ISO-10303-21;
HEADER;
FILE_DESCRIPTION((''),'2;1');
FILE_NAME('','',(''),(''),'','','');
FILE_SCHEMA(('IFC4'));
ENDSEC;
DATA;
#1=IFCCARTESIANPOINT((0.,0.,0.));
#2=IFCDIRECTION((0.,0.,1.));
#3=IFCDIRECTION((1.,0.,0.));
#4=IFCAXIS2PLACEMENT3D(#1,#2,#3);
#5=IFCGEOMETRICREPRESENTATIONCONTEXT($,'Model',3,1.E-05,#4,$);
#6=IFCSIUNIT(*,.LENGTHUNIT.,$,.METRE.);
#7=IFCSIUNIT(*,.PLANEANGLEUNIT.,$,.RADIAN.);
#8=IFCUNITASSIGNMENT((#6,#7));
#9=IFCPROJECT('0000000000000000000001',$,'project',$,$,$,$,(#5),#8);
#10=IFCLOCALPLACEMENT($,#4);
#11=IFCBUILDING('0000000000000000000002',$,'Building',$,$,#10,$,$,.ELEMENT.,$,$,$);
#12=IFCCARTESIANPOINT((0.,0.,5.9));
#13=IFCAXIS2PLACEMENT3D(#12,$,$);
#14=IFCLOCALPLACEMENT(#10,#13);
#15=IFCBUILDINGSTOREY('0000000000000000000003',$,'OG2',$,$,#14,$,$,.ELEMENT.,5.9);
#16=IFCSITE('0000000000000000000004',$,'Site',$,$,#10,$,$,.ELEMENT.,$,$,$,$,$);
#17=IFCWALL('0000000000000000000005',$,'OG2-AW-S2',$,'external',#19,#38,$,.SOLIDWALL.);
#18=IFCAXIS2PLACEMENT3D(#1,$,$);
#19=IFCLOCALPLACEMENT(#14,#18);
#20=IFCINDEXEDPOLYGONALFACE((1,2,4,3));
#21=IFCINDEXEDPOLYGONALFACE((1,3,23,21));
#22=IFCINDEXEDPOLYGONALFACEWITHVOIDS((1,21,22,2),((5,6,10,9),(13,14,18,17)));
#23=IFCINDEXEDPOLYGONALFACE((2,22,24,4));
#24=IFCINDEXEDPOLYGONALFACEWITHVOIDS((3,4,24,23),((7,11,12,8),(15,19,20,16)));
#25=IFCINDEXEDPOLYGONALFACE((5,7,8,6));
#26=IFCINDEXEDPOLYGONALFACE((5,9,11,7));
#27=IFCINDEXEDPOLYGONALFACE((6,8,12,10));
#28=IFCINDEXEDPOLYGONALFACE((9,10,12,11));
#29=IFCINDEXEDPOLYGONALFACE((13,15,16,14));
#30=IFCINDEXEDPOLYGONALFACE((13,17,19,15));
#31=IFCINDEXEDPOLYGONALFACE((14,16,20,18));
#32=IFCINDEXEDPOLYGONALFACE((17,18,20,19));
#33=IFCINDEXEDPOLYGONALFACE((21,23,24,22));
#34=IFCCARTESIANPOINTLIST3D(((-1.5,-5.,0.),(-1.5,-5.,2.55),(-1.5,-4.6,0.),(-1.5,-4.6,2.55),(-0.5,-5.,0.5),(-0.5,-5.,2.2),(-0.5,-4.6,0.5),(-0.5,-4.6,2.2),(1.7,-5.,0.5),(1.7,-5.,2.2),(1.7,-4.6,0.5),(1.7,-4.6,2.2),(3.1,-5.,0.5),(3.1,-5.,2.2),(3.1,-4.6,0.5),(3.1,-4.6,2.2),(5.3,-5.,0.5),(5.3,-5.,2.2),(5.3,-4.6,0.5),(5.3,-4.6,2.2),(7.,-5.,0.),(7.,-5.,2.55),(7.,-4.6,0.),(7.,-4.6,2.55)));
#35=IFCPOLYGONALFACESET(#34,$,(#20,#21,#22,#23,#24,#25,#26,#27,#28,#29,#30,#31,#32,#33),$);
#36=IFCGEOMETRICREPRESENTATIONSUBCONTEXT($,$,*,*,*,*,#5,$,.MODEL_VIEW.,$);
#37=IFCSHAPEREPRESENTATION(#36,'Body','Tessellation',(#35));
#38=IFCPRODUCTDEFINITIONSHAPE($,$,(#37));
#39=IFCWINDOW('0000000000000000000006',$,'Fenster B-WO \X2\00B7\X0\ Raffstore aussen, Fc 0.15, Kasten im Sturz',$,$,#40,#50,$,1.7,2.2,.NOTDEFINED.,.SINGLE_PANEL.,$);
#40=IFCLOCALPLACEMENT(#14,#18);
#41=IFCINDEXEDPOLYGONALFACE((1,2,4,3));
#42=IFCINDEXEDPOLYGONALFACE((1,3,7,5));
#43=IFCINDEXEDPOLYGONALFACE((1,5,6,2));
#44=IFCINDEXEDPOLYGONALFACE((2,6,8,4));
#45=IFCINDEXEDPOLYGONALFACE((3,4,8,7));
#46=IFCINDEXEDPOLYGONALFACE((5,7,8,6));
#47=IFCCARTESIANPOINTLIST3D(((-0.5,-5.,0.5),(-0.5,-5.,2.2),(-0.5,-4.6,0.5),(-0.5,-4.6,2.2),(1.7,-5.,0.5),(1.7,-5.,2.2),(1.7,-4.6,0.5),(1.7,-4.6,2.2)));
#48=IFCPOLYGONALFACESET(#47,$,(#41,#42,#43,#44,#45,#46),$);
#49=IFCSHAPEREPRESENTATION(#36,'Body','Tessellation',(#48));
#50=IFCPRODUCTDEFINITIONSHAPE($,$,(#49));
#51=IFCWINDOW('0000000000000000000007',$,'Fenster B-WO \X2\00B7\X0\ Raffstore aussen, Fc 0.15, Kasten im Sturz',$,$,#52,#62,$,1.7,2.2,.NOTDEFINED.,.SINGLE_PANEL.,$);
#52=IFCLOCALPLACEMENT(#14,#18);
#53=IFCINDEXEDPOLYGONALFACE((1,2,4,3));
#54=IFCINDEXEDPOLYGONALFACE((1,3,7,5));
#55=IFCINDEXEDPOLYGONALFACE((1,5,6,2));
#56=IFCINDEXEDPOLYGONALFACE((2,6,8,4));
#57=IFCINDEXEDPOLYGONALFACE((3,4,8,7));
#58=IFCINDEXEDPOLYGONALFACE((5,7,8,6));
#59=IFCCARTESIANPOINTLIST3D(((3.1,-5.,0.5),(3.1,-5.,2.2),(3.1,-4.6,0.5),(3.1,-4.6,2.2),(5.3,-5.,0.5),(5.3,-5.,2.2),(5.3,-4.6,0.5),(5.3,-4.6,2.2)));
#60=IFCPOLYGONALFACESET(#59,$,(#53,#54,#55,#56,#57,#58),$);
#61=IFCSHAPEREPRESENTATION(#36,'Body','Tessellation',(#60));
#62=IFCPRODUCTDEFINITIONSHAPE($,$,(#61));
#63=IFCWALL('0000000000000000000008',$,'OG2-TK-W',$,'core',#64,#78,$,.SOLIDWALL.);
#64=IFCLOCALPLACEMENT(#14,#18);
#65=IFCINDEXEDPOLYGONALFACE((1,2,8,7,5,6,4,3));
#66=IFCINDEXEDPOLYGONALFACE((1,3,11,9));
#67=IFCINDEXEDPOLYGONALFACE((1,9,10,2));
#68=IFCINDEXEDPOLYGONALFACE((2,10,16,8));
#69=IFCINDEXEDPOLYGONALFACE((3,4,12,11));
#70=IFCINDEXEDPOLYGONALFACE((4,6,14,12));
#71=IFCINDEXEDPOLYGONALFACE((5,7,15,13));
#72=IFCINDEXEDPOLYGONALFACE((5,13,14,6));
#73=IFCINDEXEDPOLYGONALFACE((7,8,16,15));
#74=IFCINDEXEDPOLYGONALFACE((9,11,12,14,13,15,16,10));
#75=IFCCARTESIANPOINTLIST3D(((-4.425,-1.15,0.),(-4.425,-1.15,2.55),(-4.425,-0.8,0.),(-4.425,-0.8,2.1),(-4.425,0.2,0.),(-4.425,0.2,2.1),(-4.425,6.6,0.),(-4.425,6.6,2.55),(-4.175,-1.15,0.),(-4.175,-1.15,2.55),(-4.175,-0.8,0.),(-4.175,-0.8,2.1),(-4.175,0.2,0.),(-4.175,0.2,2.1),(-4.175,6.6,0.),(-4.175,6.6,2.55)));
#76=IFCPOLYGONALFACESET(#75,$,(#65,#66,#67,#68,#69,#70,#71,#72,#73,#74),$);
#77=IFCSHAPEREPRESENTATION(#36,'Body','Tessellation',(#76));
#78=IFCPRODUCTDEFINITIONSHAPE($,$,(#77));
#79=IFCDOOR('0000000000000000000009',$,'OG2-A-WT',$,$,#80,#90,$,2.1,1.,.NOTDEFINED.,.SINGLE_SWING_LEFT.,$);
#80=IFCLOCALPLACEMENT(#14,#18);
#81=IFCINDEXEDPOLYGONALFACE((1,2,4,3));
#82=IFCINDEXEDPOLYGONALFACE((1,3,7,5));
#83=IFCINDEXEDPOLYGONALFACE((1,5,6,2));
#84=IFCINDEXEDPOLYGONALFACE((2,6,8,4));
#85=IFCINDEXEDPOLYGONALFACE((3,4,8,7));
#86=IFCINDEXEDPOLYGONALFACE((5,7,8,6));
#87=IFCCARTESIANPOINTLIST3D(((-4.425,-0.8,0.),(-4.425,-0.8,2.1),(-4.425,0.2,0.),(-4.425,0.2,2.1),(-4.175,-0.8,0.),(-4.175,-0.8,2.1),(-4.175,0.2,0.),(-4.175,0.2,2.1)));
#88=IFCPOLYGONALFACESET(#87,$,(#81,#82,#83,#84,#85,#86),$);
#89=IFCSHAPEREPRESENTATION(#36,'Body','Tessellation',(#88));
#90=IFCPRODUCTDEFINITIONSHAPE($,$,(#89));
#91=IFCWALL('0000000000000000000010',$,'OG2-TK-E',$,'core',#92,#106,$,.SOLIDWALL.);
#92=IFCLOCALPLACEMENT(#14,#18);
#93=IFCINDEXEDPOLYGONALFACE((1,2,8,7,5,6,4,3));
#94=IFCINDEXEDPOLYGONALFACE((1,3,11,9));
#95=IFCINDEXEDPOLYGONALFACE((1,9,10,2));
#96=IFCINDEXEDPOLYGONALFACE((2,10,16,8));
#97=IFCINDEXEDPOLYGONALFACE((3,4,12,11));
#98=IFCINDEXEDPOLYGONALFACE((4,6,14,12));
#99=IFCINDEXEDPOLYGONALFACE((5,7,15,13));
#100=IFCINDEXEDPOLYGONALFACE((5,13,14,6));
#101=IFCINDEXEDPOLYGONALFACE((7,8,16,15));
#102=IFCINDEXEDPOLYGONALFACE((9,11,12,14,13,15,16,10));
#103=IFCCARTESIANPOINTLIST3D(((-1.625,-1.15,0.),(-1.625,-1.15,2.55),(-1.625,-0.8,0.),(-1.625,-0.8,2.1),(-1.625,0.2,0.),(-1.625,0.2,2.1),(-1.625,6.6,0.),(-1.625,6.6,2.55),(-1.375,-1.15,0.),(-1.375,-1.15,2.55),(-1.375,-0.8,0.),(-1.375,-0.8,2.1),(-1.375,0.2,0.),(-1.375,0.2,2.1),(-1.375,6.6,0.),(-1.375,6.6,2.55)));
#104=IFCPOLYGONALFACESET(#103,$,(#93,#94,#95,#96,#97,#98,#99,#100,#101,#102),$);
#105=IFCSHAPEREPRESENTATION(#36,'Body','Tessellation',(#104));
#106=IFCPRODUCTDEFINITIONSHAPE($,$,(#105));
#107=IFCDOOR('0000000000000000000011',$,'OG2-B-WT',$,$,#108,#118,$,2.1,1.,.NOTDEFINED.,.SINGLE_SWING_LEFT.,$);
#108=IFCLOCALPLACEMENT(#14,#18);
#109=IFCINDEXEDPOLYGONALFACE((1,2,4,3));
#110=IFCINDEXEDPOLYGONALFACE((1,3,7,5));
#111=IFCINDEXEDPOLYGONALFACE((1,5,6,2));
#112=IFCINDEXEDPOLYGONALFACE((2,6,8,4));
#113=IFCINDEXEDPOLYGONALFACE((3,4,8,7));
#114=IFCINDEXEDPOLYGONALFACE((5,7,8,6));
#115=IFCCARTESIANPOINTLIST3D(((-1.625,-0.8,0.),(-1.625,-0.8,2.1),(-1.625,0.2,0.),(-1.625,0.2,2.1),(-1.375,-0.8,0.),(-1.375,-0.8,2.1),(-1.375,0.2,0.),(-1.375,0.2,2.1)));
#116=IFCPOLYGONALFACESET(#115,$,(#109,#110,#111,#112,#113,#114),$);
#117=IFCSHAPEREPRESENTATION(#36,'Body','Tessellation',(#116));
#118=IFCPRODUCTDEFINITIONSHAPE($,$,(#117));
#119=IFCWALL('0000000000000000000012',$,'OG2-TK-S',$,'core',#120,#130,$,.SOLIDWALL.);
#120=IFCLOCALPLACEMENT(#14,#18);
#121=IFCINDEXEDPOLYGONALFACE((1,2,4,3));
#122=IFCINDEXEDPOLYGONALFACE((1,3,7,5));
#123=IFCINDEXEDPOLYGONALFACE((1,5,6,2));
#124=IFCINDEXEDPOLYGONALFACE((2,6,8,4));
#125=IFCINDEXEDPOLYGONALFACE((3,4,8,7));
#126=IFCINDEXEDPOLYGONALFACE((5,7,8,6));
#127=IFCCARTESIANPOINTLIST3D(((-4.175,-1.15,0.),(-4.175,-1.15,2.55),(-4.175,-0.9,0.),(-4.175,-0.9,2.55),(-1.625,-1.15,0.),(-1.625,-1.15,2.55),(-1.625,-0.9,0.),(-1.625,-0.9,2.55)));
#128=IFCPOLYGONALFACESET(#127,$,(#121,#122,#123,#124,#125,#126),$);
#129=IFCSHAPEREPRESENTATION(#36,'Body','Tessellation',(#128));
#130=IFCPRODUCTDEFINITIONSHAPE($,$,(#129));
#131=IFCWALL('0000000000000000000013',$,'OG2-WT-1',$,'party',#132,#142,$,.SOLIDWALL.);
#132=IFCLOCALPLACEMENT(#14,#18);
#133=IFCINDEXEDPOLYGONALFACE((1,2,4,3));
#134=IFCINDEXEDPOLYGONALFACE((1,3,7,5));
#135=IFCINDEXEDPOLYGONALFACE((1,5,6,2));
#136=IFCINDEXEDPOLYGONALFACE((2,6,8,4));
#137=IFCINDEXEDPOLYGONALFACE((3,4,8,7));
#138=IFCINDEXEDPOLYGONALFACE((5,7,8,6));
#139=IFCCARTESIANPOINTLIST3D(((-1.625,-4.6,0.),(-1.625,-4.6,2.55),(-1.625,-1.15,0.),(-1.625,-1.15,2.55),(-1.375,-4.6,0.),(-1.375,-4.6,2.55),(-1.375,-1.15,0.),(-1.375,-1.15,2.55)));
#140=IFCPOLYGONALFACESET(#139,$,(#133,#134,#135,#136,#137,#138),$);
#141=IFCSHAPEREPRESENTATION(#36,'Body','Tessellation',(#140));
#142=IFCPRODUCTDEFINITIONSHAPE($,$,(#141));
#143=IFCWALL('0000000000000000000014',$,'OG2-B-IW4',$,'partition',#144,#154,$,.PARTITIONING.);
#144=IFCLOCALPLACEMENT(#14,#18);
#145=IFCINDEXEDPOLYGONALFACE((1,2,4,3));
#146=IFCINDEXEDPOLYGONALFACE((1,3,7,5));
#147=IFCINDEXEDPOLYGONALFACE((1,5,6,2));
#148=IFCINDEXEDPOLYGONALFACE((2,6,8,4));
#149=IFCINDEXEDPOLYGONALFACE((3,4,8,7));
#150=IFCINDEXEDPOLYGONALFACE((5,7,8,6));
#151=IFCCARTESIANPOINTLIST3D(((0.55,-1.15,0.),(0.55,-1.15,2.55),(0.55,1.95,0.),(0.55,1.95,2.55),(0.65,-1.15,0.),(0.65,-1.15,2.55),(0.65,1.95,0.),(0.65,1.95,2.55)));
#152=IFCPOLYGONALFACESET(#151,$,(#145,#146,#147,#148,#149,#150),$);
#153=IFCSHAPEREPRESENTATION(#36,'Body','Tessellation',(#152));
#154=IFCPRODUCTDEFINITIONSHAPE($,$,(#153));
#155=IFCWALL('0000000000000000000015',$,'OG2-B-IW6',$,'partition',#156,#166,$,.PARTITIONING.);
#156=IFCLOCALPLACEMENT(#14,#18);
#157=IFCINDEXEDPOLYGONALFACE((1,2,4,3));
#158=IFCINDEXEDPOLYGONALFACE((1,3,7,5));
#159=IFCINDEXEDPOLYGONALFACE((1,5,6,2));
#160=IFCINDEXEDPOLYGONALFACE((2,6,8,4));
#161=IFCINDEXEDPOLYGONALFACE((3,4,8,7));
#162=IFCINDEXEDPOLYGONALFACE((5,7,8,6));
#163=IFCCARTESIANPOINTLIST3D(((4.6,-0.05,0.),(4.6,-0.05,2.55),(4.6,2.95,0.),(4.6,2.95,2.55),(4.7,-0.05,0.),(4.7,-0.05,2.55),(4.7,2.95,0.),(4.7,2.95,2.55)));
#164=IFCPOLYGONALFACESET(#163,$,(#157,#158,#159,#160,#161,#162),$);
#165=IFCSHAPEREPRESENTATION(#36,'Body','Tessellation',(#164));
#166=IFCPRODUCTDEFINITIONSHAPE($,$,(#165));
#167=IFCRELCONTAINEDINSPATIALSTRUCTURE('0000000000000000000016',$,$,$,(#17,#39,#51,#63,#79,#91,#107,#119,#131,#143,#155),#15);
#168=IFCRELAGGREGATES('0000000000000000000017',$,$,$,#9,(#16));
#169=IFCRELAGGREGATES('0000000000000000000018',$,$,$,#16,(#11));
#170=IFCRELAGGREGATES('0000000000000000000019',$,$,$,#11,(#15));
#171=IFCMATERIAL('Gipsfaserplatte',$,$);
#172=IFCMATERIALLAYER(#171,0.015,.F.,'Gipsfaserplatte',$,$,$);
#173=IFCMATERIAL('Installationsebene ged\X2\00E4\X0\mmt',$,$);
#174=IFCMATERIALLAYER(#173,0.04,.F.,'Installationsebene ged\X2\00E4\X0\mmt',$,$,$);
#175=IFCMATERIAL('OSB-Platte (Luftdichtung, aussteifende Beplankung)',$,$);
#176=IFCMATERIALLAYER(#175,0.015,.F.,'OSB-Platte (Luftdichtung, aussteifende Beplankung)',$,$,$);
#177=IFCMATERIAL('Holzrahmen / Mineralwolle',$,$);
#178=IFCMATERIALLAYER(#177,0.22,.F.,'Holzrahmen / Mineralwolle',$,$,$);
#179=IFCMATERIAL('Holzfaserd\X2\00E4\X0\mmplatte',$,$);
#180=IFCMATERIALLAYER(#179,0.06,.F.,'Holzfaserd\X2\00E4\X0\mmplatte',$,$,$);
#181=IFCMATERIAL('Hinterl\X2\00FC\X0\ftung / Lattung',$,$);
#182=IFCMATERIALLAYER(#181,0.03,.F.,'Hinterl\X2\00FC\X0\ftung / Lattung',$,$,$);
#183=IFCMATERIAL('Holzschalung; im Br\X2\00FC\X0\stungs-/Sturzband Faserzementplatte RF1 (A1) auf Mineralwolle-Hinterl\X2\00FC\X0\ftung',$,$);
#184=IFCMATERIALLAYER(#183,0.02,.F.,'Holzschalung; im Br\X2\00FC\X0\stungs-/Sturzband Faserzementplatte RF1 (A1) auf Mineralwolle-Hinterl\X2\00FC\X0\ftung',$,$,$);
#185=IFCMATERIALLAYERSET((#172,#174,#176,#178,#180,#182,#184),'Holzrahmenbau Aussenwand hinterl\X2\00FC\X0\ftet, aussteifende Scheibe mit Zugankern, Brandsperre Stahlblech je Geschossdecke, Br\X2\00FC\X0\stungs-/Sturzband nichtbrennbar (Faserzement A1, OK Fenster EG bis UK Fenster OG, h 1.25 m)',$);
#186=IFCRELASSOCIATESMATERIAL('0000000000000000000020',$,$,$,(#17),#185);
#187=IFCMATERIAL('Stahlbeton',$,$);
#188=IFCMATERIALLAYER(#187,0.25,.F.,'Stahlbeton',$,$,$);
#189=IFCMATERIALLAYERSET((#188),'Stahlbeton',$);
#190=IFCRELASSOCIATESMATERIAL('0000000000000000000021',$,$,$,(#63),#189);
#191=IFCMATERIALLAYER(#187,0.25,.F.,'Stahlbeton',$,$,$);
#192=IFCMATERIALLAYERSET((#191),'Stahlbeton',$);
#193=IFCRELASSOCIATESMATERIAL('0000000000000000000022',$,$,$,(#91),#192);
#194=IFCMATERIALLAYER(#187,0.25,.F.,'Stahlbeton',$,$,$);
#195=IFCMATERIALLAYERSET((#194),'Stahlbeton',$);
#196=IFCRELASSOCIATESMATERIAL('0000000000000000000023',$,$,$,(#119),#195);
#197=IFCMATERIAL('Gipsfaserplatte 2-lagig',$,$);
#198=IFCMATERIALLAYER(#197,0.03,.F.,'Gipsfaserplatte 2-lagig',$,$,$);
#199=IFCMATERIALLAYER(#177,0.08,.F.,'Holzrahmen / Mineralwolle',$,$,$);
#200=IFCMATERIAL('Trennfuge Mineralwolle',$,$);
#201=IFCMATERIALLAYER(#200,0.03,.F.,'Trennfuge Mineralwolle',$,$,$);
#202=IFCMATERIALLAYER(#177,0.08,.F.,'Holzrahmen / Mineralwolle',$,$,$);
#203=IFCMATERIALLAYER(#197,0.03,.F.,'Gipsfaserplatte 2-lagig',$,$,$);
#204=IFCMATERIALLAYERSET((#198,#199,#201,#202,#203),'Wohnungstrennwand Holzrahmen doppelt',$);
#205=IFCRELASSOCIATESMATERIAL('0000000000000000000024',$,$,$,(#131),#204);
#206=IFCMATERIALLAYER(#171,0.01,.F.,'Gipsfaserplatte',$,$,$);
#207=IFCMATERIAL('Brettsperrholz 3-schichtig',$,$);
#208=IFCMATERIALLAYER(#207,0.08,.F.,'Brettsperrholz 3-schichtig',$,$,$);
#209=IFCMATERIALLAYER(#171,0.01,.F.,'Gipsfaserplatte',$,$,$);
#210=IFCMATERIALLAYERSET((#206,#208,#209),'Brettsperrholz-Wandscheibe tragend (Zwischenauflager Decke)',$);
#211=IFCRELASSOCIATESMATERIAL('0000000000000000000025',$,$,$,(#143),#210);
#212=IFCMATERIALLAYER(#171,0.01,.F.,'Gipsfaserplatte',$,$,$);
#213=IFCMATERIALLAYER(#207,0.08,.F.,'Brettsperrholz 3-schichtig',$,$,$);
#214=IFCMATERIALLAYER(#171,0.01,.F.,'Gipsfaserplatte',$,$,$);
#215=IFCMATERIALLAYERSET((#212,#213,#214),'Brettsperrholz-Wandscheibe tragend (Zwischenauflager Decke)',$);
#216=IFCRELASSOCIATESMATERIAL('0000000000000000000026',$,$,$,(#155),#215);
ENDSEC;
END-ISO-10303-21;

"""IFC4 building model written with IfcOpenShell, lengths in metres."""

from ifc_helpers import new_model, si_unit, frame, frame_2d, origin, origin_with_axes, place, context, subcontext, project, spatial, rectangle, extrude, material, layer, layer_set, element, fill, save


model = new_model("IFC4")

# Units and contexts
model_context = context("Model", 3, precision=1e-05, world=origin_with_axes())
sub_context = subcontext(model_context, None, None, "MODEL_VIEW")
ifc_project = project(units=[si_unit("LENGTHUNIT", "METRE"), si_unit("PLANEANGLEUNIT", "RADIAN")], contexts=[model_context])

# Site, building, storey
placement = place(None, origin_with_axes())
site = spatial("IfcSite", under=ifc_project, at=placement, Name="Site", CompositionType="ELEMENT")
building = spatial("IfcBuilding", under=site, at=placement, Name="Building", CompositionType="ELEMENT")
storey_placement = place(placement, frame((0.0, 0.0, 5.9)))
storey = spatial("IfcBuildingStorey", under=building, at=storey_placement, Name="OG2", CompositionType="ELEMENT", Elevation=5.9)

# Wall, openings, windows
ifc_material_1 = material(Name="Gipsfaserplatte")
ifc_layer_1 = layer(ifc_material_1, 0.015, ventilated=False, Name="Gipsfaserplatte")
ifc_material_2 = material(Name="Installationsebene gedämmt")
ifc_layer_2 = layer(ifc_material_2, 0.04, ventilated=False, Name="Installationsebene gedämmt")
ifc_material_3 = material(Name="OSB-Platte (Luftdichtung, aussteifende Beplankung)")
ifc_layer_3 = layer(ifc_material_3, 0.015, ventilated=False, Name="OSB-Platte (Luftdichtung, aussteifende Beplankung)")
ifc_material_4 = material(Name="Holzrahmen / Mineralwolle")
ifc_layer_4 = layer(ifc_material_4, 0.22, ventilated=False, Name="Holzrahmen / Mineralwolle")
ifc_material_5 = material(Name="Holzfaserdämmplatte")
ifc_layer_5 = layer(ifc_material_5, 0.06, ventilated=False, Name="Holzfaserdämmplatte")
ifc_material_6 = material(Name="Hinterlüftung / Lattung")
ifc_layer_6 = layer(ifc_material_6, 0.03, ventilated=False, Name="Hinterlüftung / Lattung")
ifc_material_7 = material(Name="Holzschalung; im Brüstungs-/Sturzband Faserzementplatte RF1 (A1) auf Mineralwolle-Hinterlüftung")
ifc_layer_7 = layer(ifc_material_7, 0.02, ventilated=False, Name="Holzschalung; im Brüstungs-/Sturzband Faserzementplatte RF1 (A1) auf Mineralwolle-Hinterlüftung")
ifc_layer_set_1 = layer_set([ifc_layer_1, ifc_layer_2, ifc_layer_3, ifc_layer_4, ifc_layer_5, ifc_layer_6, ifc_layer_7], Name="Holzrahmenbau Aussenwand hinterlüftet, aussteifende Scheibe mit Zugankern, Brandsperre Stahlblech je Geschossdecke, Brüstungs-/Sturzband nichtbrennbar (Faserzement A1, OK Fenster EG bis UK Fenster OG, h 1.25 m)")
wall_1_placement = place(storey_placement, frame((7.0, -4.8, 0.0), z_axis=(0.0, 0.0, 1.0), x_axis=(-1.0, 0.0, 0.0)))
wall_1 = element("IfcWall", 1, at=wall_1_placement, inside=storey, material=ifc_layer_set_1, Name="OG2-AW-S2", ObjectType="external", PredefinedType="SOLIDWALL", context=sub_context, shape_type="SweptSolid", body=[
    extrude(rectangle(XDim=8.5, YDim=0.4, at=frame_2d((4.25, 0.0))), origin(), (0.0, 0.0, 1.0), 2.55),
])
opening_1_placement = place(wall_1_placement, frame((6.4, 0.25, 0.5), z_axis=(0.0, -1.0, 0.0), x_axis=(1.0, 0.0, 0.0)))
opening_1 = element("IfcOpeningElement", 2, at=opening_1_placement, cuts=wall_1, PredefinedType="OPENING", context=sub_context, shape_type="SweptSolid", body=[
    extrude(rectangle(XDim=2.2, YDim=1.7, at=frame_2d((0.0, 0.85))), origin(), (0.0, 0.0, 1.0), 0.5),
])
opening_2_placement = place(wall_1_placement, frame((2.8, 0.25, 0.5), z_axis=(0.0, -1.0, 0.0), x_axis=(1.0, 0.0, 0.0)))
opening_2 = element("IfcOpeningElement", 3, at=opening_2_placement, cuts=wall_1, PredefinedType="OPENING", context=sub_context, shape_type="SweptSolid", body=[
    extrude(rectangle(XDim=2.2, YDim=1.7, at=frame_2d((0.0, 0.85))), origin(), (0.0, 0.0, 1.0), 0.5),
])
window_1_placement = place(wall_1_placement, frame((6.4, 0.2, 0.5), z_axis=(0.0, -1.0, 0.0), x_axis=(1.0, 0.0, 0.0)))
window_1 = element("IfcWindow", 4, at=window_1_placement, inside=storey, Name="Fenster B-WO · Raffstore aussen, Fc 0.15, Kasten im Sturz", OverallHeight=1.7, OverallWidth=2.2, PartitioningType="SINGLE_PANEL", PredefinedType="NOTDEFINED", context=sub_context, shape_type="SweptSolid", body=[
    extrude(rectangle(XDim=2.2, YDim=1.7, at=frame_2d((0.0, 0.85))), origin(), (0.0, 0.0, 1.0), 0.4),
])
fill(opening_1, window_1)
window_2_placement = place(wall_1_placement, frame((2.8, 0.2, 0.5), z_axis=(0.0, -1.0, 0.0), x_axis=(1.0, 0.0, 0.0)))
window_2 = element("IfcWindow", 5, at=window_2_placement, inside=storey, Name="Fenster B-WO · Raffstore aussen, Fc 0.15, Kasten im Sturz", OverallHeight=1.7, OverallWidth=2.2, PartitioningType="SINGLE_PANEL", PredefinedType="NOTDEFINED", context=sub_context, shape_type="SweptSolid", body=[
    extrude(rectangle(XDim=2.2, YDim=1.7, at=frame_2d((0.0, 0.85))), origin(), (0.0, 0.0, 1.0), 0.4),
])
fill(opening_2, window_2)

# Walls, openings, doors
ifc_material_8 = material(Name="Stahlbeton")
ifc_layer_8 = layer(ifc_material_8, 0.25, ventilated=False, Name="Stahlbeton")
ifc_layer_set_2 = layer_set([ifc_layer_8], Name="Stahlbeton")
wall_2_placement = place(storey_placement, frame((-4.3, -1.15, 0.0), z_axis=(0.0, 0.0, 1.0), x_axis=(0.0, 1.0, 0.0)))
wall_2 = element("IfcWall", 6, at=wall_2_placement, inside=storey, material=ifc_layer_set_2, Name="OG2-TK-W", ObjectType="core", PredefinedType="SOLIDWALL", context=sub_context, shape_type="SweptSolid", body=[
    extrude(rectangle(XDim=7.75, YDim=0.25, at=frame_2d((3.875, 0.0))), origin(), (0.0, 0.0, 1.0), 2.55),
])
opening_3_placement = place(wall_2_placement, frame((0.85, 0.175, 0.0), z_axis=(0.0, -1.0, 0.0), x_axis=(1.0, 0.0, 0.0)))
opening_3 = element("IfcOpeningElement", 7, at=opening_3_placement, cuts=wall_2, PredefinedType="OPENING", context=sub_context, shape_type="SweptSolid", body=[
    extrude(rectangle(XDim=1.0, YDim=2.1, at=frame_2d((0.0, 1.05))), origin(), (0.0, 0.0, 1.0), 0.35),
])
door_1_placement = place(wall_2_placement, frame((0.85, 0.125, 0.0), z_axis=(0.0, -1.0, 0.0), x_axis=(1.0, 0.0, 0.0)))
door_1 = element("IfcDoor", 8, at=door_1_placement, inside=storey, Name="OG2-A-WT", OperationType="SINGLE_SWING_LEFT", OverallHeight=2.1, OverallWidth=1.0, PredefinedType="NOTDEFINED", context=sub_context, shape_type="SweptSolid", body=[
    extrude(rectangle(XDim=1.0, YDim=2.1, at=frame_2d((0.0, 1.05))), origin(), (0.0, 0.0, 1.0), 0.25),
])
fill(opening_3, door_1)
ifc_layer_9 = layer(ifc_material_8, 0.25, ventilated=False, Name="Stahlbeton")
ifc_layer_set_3 = layer_set([ifc_layer_9], Name="Stahlbeton")
wall_3_placement = place(storey_placement, frame((-1.5, -1.15, 0.0), z_axis=(0.0, 0.0, 1.0), x_axis=(0.0, 1.0, 0.0)))
wall_3 = element("IfcWall", 9, at=wall_3_placement, inside=storey, material=ifc_layer_set_3, Name="OG2-TK-E", ObjectType="core", PredefinedType="SOLIDWALL", context=sub_context, shape_type="SweptSolid", body=[
    extrude(rectangle(XDim=7.75, YDim=0.25, at=frame_2d((3.875, 0.0))), origin(), (0.0, 0.0, 1.0), 2.55),
])
opening_4_placement = place(wall_3_placement, frame((0.85, 0.175, 0.0), z_axis=(0.0, -1.0, 0.0), x_axis=(1.0, 0.0, 0.0)))
opening_4 = element("IfcOpeningElement", 10, at=opening_4_placement, cuts=wall_3, PredefinedType="OPENING", context=sub_context, shape_type="SweptSolid", body=[
    extrude(rectangle(XDim=1.0, YDim=2.1, at=frame_2d((0.0, 1.05))), origin(), (0.0, 0.0, 1.0), 0.35),
])
door_2_placement = place(wall_3_placement, frame((0.85, 0.125, 0.0), z_axis=(0.0, -1.0, 0.0), x_axis=(1.0, 0.0, 0.0)))
door_2 = element("IfcDoor", 11, at=door_2_placement, inside=storey, Name="OG2-B-WT", OperationType="SINGLE_SWING_LEFT", OverallHeight=2.1, OverallWidth=1.0, PredefinedType="NOTDEFINED", context=sub_context, shape_type="SweptSolid", body=[
    extrude(rectangle(XDim=1.0, YDim=2.1, at=frame_2d((0.0, 1.05))), origin(), (0.0, 0.0, 1.0), 0.25),
])
fill(opening_4, door_2)

# Walls
ifc_layer_10 = layer(ifc_material_8, 0.25, ventilated=False, Name="Stahlbeton")
ifc_layer_set_4 = layer_set([ifc_layer_10], Name="Stahlbeton")
wall_4_placement = place(storey_placement, frame((-4.175, -1.025, 0.0), z_axis=(0.0, 0.0, 1.0), x_axis=(1.0, 0.0, 0.0)))
element("IfcWall", 12, at=wall_4_placement, inside=storey, material=ifc_layer_set_4, Name="OG2-TK-S", ObjectType="core", PredefinedType="SOLIDWALL", context=sub_context, shape_type="SweptSolid", body=[
    extrude(rectangle(XDim=2.55, YDim=0.25, at=frame_2d((1.275, 0.0))), origin(), (0.0, 0.0, 1.0), 2.55),
])
ifc_material_9 = material(Name="Gipsfaserplatte 2-lagig")
ifc_layer_11 = layer(ifc_material_9, 0.03, ventilated=False, Name="Gipsfaserplatte 2-lagig")
ifc_layer_12 = layer(ifc_material_4, 0.08, ventilated=False, Name="Holzrahmen / Mineralwolle")
ifc_material_10 = material(Name="Trennfuge Mineralwolle")
ifc_layer_13 = layer(ifc_material_10, 0.03, ventilated=False, Name="Trennfuge Mineralwolle")
ifc_layer_14 = layer(ifc_material_4, 0.08, ventilated=False, Name="Holzrahmen / Mineralwolle")
ifc_layer_15 = layer(ifc_material_9, 0.03, ventilated=False, Name="Gipsfaserplatte 2-lagig")
ifc_layer_set_5 = layer_set([ifc_layer_11, ifc_layer_12, ifc_layer_13, ifc_layer_14, ifc_layer_15], Name="Wohnungstrennwand Holzrahmen doppelt")
wall_5_placement = place(storey_placement, frame((-1.5, -1.15, 0.0), z_axis=(0.0, 0.0, 1.0), x_axis=(0.0, -1.0, 0.0)))
element("IfcWall", 13, at=wall_5_placement, inside=storey, material=ifc_layer_set_5, Name="OG2-WT-1", ObjectType="party", PredefinedType="SOLIDWALL", context=sub_context, shape_type="SweptSolid", body=[
    extrude(rectangle(XDim=3.45, YDim=0.25, at=frame_2d((1.725, 0.0))), origin(), (0.0, 0.0, 1.0), 2.55),
])
ifc_layer_16 = layer(ifc_material_1, 0.01, ventilated=False, Name="Gipsfaserplatte")
ifc_material_11 = material(Name="Brettsperrholz 3-schichtig")
ifc_layer_17 = layer(ifc_material_11, 0.08, ventilated=False, Name="Brettsperrholz 3-schichtig")
ifc_layer_18 = layer(ifc_material_1, 0.01, ventilated=False, Name="Gipsfaserplatte")
ifc_layer_set_6 = layer_set([ifc_layer_16, ifc_layer_17, ifc_layer_18], Name="Brettsperrholz-Wandscheibe tragend (Zwischenauflager Decke)")
wall_6_placement = place(storey_placement, frame((0.6, -1.15, 0.0), z_axis=(0.0, 0.0, 1.0), x_axis=(0.0, 1.0, 0.0)))
element("IfcWall", 14, at=wall_6_placement, inside=storey, material=ifc_layer_set_6, Name="OG2-B-IW4", ObjectType="partition", PredefinedType="PARTITIONING", context=sub_context, shape_type="SweptSolid", body=[
    extrude(rectangle(XDim=3.1, YDim=0.1, at=frame_2d((1.55, 0.0))), origin(), (0.0, 0.0, 1.0), 2.55),
])
ifc_layer_19 = layer(ifc_material_1, 0.01, ventilated=False, Name="Gipsfaserplatte")
ifc_layer_20 = layer(ifc_material_11, 0.08, ventilated=False, Name="Brettsperrholz 3-schichtig")
ifc_layer_21 = layer(ifc_material_1, 0.01, ventilated=False, Name="Gipsfaserplatte")
ifc_layer_set_7 = layer_set([ifc_layer_19, ifc_layer_20, ifc_layer_21], Name="Brettsperrholz-Wandscheibe tragend (Zwischenauflager Decke)")
wall_7_placement = place(storey_placement, frame((4.65, -0.05, 0.0), z_axis=(0.0, 0.0, 1.0), x_axis=(0.0, 1.0, 0.0)))
element("IfcWall", 15, at=wall_7_placement, inside=storey, material=ifc_layer_set_7, Name="OG2-B-IW6", ObjectType="partition", PredefinedType="PARTITIONING", context=sub_context, shape_type="SweptSolid", body=[
    extrude(rectangle(XDim=3.0, YDim=0.1, at=frame_2d((1.5, 0.0))), origin(), (0.0, 0.0, 1.0), 2.55),
])

save(model, "model.ifc")
